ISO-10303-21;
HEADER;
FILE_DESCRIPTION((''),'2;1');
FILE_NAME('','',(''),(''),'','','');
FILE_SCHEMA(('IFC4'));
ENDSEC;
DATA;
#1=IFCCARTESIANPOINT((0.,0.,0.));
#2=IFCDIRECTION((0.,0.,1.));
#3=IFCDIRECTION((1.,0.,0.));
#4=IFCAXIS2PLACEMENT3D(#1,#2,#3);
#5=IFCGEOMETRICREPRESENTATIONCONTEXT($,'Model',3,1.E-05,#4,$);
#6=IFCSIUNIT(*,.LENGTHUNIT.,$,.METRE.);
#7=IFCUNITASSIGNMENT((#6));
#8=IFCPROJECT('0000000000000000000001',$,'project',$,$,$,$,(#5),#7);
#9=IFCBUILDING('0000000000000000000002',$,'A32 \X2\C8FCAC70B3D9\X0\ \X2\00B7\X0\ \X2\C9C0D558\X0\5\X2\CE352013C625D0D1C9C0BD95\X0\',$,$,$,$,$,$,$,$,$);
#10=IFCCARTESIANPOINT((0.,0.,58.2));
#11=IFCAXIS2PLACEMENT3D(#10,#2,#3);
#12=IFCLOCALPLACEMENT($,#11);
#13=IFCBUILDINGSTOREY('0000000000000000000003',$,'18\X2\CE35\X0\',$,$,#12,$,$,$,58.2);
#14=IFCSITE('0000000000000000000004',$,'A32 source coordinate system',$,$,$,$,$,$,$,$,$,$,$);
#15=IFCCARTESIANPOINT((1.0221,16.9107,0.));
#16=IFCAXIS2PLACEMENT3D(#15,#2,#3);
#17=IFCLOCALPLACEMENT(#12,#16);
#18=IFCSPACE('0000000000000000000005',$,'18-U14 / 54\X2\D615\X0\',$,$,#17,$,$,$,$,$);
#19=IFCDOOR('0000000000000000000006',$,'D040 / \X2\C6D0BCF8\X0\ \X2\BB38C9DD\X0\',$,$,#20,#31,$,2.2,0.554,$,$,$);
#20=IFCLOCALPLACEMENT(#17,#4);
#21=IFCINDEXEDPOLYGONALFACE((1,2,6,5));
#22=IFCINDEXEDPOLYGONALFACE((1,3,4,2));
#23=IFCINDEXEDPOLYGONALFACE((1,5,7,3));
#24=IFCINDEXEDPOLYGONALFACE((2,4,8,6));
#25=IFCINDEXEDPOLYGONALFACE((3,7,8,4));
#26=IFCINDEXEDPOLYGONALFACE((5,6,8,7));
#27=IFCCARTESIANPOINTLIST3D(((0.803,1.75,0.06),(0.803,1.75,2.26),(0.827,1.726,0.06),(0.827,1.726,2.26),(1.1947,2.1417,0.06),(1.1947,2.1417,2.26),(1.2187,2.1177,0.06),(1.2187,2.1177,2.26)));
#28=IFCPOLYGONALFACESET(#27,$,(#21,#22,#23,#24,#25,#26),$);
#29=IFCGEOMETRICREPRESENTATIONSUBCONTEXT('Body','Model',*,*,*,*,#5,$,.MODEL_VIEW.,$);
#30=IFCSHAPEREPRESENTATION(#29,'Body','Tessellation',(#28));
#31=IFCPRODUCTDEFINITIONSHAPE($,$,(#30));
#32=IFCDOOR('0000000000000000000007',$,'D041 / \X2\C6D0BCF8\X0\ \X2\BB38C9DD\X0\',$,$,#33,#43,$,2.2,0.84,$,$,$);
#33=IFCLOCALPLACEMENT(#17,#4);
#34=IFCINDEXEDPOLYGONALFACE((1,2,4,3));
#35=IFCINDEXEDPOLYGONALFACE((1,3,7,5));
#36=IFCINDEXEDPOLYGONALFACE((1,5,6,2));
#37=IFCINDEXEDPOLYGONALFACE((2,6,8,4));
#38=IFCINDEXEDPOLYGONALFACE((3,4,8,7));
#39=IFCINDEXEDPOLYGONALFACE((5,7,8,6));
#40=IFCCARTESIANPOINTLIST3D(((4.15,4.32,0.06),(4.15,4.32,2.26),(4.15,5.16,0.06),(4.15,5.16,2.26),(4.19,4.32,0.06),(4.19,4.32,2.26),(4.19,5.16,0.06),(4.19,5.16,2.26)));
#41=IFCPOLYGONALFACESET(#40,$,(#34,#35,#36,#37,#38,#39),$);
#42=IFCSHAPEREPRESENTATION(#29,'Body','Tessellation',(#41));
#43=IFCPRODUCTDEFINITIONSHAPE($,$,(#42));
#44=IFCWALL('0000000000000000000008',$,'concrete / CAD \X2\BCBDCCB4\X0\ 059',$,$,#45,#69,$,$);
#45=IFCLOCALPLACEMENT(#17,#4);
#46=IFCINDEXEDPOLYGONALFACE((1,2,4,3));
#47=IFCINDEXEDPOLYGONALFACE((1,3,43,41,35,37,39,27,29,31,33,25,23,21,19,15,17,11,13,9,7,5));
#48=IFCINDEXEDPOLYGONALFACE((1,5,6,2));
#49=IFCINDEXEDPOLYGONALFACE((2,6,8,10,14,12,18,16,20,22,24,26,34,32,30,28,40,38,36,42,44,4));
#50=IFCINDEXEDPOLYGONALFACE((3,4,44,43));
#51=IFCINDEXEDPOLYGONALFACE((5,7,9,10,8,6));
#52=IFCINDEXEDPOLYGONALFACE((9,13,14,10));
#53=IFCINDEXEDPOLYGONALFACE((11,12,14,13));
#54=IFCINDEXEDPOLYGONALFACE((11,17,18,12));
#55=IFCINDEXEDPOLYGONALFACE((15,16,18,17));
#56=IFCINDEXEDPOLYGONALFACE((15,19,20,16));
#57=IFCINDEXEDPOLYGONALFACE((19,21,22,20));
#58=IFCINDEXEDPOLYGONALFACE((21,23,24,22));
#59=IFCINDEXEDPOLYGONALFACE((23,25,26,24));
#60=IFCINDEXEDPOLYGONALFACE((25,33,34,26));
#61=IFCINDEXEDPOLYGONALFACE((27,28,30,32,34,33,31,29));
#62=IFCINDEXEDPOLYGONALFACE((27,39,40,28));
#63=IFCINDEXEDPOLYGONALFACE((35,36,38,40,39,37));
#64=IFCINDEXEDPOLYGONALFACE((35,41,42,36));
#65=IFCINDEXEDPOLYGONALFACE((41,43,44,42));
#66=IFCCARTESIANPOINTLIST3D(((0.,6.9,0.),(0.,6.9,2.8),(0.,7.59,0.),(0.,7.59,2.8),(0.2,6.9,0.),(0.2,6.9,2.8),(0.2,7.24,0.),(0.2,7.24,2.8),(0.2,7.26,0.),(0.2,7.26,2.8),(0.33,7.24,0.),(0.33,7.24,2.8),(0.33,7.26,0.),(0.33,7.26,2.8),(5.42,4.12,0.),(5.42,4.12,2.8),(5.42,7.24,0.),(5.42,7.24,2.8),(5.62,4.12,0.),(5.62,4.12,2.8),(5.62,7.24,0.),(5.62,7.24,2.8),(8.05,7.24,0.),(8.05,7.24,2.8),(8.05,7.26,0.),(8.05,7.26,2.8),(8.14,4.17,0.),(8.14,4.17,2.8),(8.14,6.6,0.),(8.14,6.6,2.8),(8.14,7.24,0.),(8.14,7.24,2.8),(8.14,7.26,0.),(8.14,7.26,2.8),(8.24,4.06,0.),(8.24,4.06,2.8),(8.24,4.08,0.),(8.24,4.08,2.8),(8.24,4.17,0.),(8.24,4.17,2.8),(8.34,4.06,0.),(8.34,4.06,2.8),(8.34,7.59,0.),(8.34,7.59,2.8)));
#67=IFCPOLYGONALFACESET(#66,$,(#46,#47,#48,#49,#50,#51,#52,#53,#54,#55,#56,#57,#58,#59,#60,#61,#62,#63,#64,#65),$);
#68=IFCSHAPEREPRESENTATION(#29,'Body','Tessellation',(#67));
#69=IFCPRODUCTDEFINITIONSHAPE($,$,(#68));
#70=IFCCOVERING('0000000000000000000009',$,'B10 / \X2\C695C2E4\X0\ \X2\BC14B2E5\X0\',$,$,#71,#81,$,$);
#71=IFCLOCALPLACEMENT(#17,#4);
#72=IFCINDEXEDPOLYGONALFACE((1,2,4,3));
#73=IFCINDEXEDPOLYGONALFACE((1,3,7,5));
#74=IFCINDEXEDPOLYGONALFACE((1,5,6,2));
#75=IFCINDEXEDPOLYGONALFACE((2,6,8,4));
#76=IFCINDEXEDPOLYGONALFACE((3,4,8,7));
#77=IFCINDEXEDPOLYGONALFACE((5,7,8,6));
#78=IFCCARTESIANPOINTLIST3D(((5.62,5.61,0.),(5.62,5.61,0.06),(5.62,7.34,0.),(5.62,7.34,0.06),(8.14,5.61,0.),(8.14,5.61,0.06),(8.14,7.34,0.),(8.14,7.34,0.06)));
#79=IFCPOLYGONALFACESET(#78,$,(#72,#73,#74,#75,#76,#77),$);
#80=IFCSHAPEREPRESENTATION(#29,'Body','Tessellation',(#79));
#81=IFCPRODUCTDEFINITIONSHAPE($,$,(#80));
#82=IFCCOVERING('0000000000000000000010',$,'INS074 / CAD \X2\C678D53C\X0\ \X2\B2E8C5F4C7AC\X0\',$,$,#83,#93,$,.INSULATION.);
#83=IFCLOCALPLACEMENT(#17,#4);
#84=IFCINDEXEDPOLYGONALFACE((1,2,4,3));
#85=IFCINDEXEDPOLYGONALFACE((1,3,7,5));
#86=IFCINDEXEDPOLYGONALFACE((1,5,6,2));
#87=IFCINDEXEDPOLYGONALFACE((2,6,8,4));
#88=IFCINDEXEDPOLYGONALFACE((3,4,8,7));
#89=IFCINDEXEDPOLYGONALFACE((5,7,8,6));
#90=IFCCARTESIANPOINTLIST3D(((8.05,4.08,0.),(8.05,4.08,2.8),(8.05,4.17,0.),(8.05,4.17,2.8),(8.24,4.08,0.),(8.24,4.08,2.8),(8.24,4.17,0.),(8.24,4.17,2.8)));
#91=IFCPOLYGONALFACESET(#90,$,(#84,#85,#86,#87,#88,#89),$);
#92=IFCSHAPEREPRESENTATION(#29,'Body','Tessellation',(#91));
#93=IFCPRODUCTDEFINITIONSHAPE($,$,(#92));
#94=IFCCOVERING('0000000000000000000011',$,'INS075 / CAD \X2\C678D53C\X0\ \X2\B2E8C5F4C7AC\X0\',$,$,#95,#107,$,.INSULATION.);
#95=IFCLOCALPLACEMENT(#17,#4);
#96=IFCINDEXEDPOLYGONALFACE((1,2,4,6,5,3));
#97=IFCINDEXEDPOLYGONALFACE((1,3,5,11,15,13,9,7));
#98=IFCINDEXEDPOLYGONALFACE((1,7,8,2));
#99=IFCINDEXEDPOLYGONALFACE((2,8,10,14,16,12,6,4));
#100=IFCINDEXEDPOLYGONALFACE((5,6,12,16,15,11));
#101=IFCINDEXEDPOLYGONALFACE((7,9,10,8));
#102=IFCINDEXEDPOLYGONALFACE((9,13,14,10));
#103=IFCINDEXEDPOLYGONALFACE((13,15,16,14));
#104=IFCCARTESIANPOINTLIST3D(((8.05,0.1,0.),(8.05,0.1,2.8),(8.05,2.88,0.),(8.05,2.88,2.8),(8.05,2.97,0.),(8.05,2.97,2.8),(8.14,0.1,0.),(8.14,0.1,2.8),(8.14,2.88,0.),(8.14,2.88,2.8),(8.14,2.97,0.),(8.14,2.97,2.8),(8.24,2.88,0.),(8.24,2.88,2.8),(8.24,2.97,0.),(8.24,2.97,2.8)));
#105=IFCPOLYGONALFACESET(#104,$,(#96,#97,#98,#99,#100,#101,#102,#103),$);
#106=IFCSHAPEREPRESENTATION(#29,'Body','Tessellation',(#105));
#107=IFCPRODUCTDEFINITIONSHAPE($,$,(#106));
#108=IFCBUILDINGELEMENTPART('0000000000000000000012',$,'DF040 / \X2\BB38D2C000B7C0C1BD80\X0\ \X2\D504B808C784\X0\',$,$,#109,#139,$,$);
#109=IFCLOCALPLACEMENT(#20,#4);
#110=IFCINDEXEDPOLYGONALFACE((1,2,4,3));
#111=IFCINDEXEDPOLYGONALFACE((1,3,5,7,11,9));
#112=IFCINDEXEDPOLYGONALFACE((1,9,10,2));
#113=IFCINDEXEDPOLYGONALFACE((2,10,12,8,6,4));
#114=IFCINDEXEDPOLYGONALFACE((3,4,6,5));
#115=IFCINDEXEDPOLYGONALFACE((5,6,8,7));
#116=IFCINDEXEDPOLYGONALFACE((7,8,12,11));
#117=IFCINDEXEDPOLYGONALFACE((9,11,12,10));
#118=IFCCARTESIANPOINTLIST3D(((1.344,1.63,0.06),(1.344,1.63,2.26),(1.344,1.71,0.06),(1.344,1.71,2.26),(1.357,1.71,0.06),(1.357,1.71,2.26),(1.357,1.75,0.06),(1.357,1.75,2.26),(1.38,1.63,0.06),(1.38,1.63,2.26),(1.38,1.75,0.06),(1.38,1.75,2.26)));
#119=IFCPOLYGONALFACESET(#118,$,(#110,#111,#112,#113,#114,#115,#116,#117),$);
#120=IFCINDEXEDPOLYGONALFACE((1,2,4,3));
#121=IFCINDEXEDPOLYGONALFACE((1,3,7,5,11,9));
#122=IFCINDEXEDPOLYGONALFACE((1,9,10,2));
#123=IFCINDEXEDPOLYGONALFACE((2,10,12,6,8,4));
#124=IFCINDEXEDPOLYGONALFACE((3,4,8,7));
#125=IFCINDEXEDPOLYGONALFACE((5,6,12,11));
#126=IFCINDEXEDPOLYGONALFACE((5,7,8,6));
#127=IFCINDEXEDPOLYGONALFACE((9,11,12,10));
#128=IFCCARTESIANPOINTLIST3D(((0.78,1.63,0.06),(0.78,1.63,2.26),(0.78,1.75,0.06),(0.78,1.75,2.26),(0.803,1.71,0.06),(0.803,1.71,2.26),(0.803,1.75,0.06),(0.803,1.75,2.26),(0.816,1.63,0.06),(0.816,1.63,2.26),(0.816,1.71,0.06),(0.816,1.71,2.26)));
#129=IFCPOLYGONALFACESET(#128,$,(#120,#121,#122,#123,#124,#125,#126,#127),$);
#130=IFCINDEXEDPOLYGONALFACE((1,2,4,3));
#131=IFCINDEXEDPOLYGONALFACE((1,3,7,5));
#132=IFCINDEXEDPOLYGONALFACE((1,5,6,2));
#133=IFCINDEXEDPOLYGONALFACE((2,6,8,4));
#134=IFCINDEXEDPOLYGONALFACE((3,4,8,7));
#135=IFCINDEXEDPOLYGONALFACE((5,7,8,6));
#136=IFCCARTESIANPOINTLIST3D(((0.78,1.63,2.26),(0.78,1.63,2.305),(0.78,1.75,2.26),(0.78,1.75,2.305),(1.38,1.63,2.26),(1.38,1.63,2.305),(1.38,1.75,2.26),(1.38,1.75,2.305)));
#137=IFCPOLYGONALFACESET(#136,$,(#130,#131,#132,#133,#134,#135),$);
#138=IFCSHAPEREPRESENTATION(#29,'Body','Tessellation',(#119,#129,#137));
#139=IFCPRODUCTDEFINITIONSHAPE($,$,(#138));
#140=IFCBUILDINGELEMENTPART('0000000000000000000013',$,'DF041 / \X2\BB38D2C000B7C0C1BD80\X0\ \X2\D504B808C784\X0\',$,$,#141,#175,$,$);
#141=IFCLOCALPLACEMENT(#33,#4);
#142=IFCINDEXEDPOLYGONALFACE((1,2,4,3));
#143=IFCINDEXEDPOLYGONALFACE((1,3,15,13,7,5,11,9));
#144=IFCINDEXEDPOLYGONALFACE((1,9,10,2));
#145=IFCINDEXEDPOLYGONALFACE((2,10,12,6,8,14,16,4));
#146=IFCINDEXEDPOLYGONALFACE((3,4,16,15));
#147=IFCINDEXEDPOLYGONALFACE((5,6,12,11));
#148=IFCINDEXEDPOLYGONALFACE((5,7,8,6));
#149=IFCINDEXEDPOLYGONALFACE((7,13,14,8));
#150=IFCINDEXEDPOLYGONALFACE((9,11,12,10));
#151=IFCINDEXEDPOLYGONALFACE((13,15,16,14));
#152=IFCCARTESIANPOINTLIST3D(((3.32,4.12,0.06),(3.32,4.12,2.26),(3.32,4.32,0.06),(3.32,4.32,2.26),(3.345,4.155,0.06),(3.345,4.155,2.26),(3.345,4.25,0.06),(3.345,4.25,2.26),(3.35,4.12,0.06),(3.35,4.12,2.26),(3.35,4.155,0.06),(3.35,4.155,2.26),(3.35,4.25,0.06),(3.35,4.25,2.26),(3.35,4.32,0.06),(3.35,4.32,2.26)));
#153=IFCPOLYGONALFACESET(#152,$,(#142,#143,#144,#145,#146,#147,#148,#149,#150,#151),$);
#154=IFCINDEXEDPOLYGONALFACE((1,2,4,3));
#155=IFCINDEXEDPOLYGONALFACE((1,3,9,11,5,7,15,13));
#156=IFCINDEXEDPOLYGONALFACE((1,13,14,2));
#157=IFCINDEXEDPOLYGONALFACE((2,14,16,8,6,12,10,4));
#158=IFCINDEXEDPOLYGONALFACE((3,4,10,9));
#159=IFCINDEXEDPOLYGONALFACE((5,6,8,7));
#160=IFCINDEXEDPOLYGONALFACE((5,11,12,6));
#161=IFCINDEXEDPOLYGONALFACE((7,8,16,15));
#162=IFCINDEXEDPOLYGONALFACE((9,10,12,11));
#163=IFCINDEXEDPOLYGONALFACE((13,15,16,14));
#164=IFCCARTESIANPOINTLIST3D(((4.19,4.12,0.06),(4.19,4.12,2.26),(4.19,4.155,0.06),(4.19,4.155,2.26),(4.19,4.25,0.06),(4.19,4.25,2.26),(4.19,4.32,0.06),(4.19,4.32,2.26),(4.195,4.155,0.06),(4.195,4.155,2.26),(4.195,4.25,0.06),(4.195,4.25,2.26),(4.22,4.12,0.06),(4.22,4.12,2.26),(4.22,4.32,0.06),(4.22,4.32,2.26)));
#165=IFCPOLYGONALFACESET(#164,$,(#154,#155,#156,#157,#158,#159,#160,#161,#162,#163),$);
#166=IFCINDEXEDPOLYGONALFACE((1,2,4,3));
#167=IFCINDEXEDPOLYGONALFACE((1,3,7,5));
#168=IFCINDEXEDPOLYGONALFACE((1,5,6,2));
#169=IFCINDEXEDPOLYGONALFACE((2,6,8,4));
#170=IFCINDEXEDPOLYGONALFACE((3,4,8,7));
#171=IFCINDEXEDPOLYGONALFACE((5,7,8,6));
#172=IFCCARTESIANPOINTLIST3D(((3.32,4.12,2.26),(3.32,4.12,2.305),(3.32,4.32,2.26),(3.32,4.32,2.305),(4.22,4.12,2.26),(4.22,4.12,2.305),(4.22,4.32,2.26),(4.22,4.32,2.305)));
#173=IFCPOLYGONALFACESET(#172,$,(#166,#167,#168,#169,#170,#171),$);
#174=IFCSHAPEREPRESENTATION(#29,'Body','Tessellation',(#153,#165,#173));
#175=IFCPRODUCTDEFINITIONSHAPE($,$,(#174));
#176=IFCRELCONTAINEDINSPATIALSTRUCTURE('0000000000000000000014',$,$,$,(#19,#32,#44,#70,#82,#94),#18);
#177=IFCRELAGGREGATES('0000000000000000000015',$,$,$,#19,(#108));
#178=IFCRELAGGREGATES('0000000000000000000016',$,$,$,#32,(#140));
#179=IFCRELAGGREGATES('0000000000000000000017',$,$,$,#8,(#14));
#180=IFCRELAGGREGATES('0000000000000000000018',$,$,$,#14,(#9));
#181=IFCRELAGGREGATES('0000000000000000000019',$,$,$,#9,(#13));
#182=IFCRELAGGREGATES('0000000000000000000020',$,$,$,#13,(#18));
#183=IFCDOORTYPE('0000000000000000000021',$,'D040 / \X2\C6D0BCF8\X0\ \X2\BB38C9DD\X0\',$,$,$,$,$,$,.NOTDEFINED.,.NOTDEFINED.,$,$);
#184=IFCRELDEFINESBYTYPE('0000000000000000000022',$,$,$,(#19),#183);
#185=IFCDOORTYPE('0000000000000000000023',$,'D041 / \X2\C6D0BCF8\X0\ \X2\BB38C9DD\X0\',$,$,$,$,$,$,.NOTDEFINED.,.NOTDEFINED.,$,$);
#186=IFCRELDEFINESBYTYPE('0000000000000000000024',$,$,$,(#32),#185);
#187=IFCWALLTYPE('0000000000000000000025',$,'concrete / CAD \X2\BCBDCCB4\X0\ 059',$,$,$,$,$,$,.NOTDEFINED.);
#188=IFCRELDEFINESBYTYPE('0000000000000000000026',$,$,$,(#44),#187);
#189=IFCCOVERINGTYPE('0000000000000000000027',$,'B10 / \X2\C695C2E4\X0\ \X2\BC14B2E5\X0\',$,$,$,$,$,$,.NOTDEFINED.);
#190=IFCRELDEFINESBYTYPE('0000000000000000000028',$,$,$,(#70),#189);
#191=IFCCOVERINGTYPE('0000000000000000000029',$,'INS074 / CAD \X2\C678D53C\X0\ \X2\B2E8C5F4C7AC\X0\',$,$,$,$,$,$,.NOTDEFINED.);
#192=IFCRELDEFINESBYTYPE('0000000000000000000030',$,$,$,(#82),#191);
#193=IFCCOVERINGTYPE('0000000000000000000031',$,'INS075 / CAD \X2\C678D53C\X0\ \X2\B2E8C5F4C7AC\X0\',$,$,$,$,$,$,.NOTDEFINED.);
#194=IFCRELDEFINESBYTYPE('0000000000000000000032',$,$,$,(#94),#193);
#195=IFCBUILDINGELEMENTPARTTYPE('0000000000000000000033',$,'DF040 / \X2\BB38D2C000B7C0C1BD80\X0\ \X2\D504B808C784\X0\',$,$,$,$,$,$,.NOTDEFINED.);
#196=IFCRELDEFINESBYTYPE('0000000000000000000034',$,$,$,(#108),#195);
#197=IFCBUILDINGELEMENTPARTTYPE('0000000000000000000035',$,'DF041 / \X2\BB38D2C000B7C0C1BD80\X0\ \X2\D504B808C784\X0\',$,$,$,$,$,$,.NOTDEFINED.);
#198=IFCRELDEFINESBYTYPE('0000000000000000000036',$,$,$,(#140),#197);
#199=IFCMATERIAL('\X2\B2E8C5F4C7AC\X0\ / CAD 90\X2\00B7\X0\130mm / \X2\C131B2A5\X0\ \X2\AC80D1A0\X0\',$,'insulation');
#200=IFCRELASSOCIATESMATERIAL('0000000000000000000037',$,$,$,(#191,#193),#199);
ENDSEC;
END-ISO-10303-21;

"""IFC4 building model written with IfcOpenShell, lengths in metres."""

from ifc_helpers import new_model, si_unit, frame, origin, origin_with_axes, place, context, subcontext, project, spatial, polyline, outline, extrude, source, transform, mapped, material, type_object, type_shapes, element, aggregate, save


model = new_model("IFC4")

# Units and contexts
model_context = context("Model", 3, precision=1e-05, world=origin_with_axes())
body_context = subcontext(model_context, "Body", "Model", "MODEL_VIEW")
ifc_project = project(units=[si_unit("LENGTHUNIT", "METRE")], contexts=[model_context])

# Site, building, storey, space
storey_placement = place(None, frame((0.0, 0.0, 58.2), z_axis=(0.0, 0.0, 1.0), x_axis=(1.0, 0.0, 0.0)))
space_1_placement = place(storey_placement, frame((1.0221, 16.9107, 0.0), z_axis=(0.0, 0.0, 1.0), x_axis=(1.0, 0.0, 0.0)))
site = spatial("IfcSite", under=ifc_project, Name="A32 source coordinate system")
building = spatial("IfcBuilding", under=site, Name="A32 주거동 · 지하5층–옥탑지붕")
storey = spatial("IfcBuildingStorey", under=building, at=storey_placement, Name="18층", Elevation=58.2)
space_1 = spatial("IfcSpace", under=storey, at=space_1_placement, Name="18-U14 / 54형")

# Doors
door_type_1 = type_object("IfcDoorType", Name="D040 / 원본 문짝", OperationType="NOTDEFINED", PredefinedType="NOTDEFINED")
shared_shape_1 = source(origin(), body_context, "Body", "SweptSolid", [
    extrude(outline(polyline([(0.803, 1.75), (1.1947, 2.1417), (1.2187, 2.1177), (0.827, 1.726), (0.803, 1.75)])), frame((0.0, 0.0, 0.06)), (0.0, 0.0, 1.0), 2.2),
])
type_shapes(door_type_1, [shared_shape_1])
door_1_placement = place(space_1_placement, origin_with_axes())
door_1 = element("IfcDoor", 1, at=door_1_placement, inside=space_1, type_object=door_type_1, Name="D040 / 원본 문짝", OverallHeight=2.2, OverallWidth=0.554, context=body_context, shape_type="MappedRepresentation", body=[
    mapped(shared_shape_1, transform((0.0, 0.0, 0.0), scale=1.0)),
])
door_type_2 = type_object("IfcDoorType", Name="D041 / 원본 문짝", OperationType="NOTDEFINED", PredefinedType="NOTDEFINED")
shared_shape_2 = source(origin(), body_context, "Body", "SweptSolid", [
    extrude(outline(polyline([(4.15, 5.16), (4.19, 5.16), (4.19, 4.32), (4.15, 4.32), (4.15, 5.16)])), frame((0.0, 0.0, 0.06)), (0.0, 0.0, 1.0), 2.2),
])
type_shapes(door_type_2, [shared_shape_2])
door_2_placement = place(space_1_placement, origin_with_axes())
door_2 = element("IfcDoor", 2, at=door_2_placement, inside=space_1, type_object=door_type_2, Name="D041 / 원본 문짝", OverallHeight=2.2, OverallWidth=0.84, context=body_context, shape_type="MappedRepresentation", body=[
    mapped(shared_shape_2, transform((0.0, 0.0, 0.0), scale=1.0)),
])

# Wall
wall_type_1 = type_object("IfcWallType", Name="concrete / CAD 벽체 059", PredefinedType="NOTDEFINED")
shared_shape_3 = source(origin(), body_context, "Body", "SweptSolid", [
    extrude(outline(polyline([(8.05, 7.26), (8.05, 7.24), (5.62, 7.24), (5.62, 4.12), (5.42, 4.12), (5.42, 7.24), (0.33, 7.24), (0.33, 7.26), (0.2, 7.26), (0.2, 7.24), (0.2, 6.9), (0.0, 6.9), (0.0, 7.59), (8.34, 7.59), (8.34, 4.06), (8.24, 4.06), (8.24, 4.08), (8.24, 4.17), (8.14, 4.17), (8.14, 6.6), (8.14, 7.24), (8.14, 7.26), (8.05, 7.26)])), origin(), (0.0, 0.0, 1.0), 2.8),
])
type_shapes(wall_type_1, [shared_shape_3])
wall_1_placement = place(space_1_placement, origin_with_axes())
element("IfcWall", 3, at=wall_1_placement, inside=space_1, type_object=wall_type_1, Name="concrete / CAD 벽체 059", context=body_context, shape_type="MappedRepresentation", body=[
    mapped(shared_shape_3, transform((0.0, 0.0, 0.0), scale=1.0)),
])

# Coverings
covering_type_1 = type_object("IfcCoveringType", Name="B10 / 욕실 바닥", PredefinedType="NOTDEFINED")
shared_shape_4 = source(origin(), body_context, "Body", "SweptSolid", [
    extrude(outline(polyline([(8.14, 5.61), (5.62, 5.61), (5.62, 7.34), (8.14, 7.34), (8.14, 5.61)])), origin(), (0.0, 0.0, 1.0), 0.06),
])
type_shapes(covering_type_1, [shared_shape_4])
covering_1_placement = place(space_1_placement, origin_with_axes())
element("IfcCovering", 4, at=covering_1_placement, inside=space_1, type_object=covering_type_1, Name="B10 / 욕실 바닥", context=body_context, shape_type="MappedRepresentation", body=[
    mapped(shared_shape_4, transform((0.0, 0.0, 0.0), scale=1.0)),
])
ifc_material = material(Name="단열재 / CAD 90·130mm / 성능 검토", Category="insulation")
covering_type_2 = type_object("IfcCoveringType", Name="INS074 / CAD 외피 단열재", PredefinedType="NOTDEFINED", material=ifc_material)
shared_shape_5 = source(origin(), body_context, "Body", "SweptSolid", [
    extrude(outline(polyline([(8.05, 4.08), (8.05, 4.17), (8.24, 4.17), (8.24, 4.08), (8.05, 4.08)])), origin(), (0.0, 0.0, 1.0), 2.8),
])
type_shapes(covering_type_2, [shared_shape_5])
covering_2_placement = place(space_1_placement, origin_with_axes())
element("IfcCovering", 5, at=covering_2_placement, inside=space_1, type_object=covering_type_2, Name="INS074 / CAD 외피 단열재", PredefinedType="INSULATION", context=body_context, shape_type="MappedRepresentation", body=[
    mapped(shared_shape_5, transform((0.0, 0.0, 0.0), scale=1.0)),
])
covering_type_3 = type_object("IfcCoveringType", Name="INS075 / CAD 외피 단열재", PredefinedType="NOTDEFINED", material=ifc_material)
shared_shape_6 = source(origin(), body_context, "Body", "SweptSolid", [
    extrude(outline(polyline([(8.24, 2.88), (8.14, 2.88), (8.14, 0.1), (8.05, 0.1), (8.05, 2.88), (8.05, 2.97), (8.14, 2.97), (8.24, 2.97), (8.24, 2.88)])), origin(), (0.0, 0.0, 1.0), 2.8),
])
type_shapes(covering_type_3, [shared_shape_6])
covering_3_placement = place(space_1_placement, origin_with_axes())
element("IfcCovering", 6, at=covering_3_placement, inside=space_1, type_object=covering_type_3, Name="INS075 / CAD 외피 단열재", PredefinedType="INSULATION", context=body_context, shape_type="MappedRepresentation", body=[
    mapped(shared_shape_6, transform((0.0, 0.0, 0.0), scale=1.0)),
])

# Building element parts
building_element_part_type_1 = type_object("IfcBuildingElementPartType", Name="DF040 / 문틀·상부 프레임", PredefinedType="NOTDEFINED")
shared_shape_7 = source(origin(), body_context, "Body", "SweptSolid", [
    extrude(outline(polyline([(1.344, 1.63), (1.344, 1.71), (1.357, 1.71), (1.357, 1.75), (1.38, 1.75), (1.38, 1.63), (1.344, 1.63)])), frame((0.0, 0.0, 0.06)), (0.0, 0.0, 1.0), 2.2),
    extrude(outline(polyline([(0.78, 1.75), (0.803, 1.75), (0.803, 1.71), (0.816, 1.71), (0.816, 1.63), (0.78, 1.63), (0.78, 1.75)])), frame((0.0, 0.0, 0.06)), (0.0, 0.0, 1.0), 2.2),
    extrude(outline(polyline([(0.78, 1.63), (0.78, 1.75), (1.38, 1.75), (1.38, 1.63), (0.78, 1.63)])), frame((0.0, 0.0, 2.26)), (0.0, 0.0, 1.0), 0.045),
])
type_shapes(building_element_part_type_1, [shared_shape_7])
building_element_part_1_placement = place(door_1_placement, origin_with_axes())
building_element_part_1 = element("IfcBuildingElementPart", 7, at=building_element_part_1_placement, type_object=building_element_part_type_1, Name="DF040 / 문틀·상부 프레임", context=body_context, shape_type="MappedRepresentation", body=[
    mapped(shared_shape_7, transform((0.0, 0.0, 0.0), scale=1.0)),
])
aggregate(door_1, [building_element_part_1])
building_element_part_type_2 = type_object("IfcBuildingElementPartType", Name="DF041 / 문틀·상부 프레임", PredefinedType="NOTDEFINED")
shared_shape_8 = source(origin(), body_context, "Body", "SweptSolid", [
    extrude(outline(polyline([(3.35, 4.32), (3.35, 4.25), (3.345, 4.25), (3.345, 4.155), (3.35, 4.155), (3.35, 4.12), (3.32, 4.12), (3.32, 4.32), (3.35, 4.32)])), frame((0.0, 0.0, 0.06)), (0.0, 0.0, 1.0), 2.2),
    extrude(outline(polyline([(4.22, 4.12), (4.19, 4.12), (4.19, 4.155), (4.195, 4.155), (4.195, 4.25), (4.19, 4.25), (4.19, 4.32), (4.22, 4.32), (4.22, 4.12)])), frame((0.0, 0.0, 0.06)), (0.0, 0.0, 1.0), 2.2),
    extrude(outline(polyline([(3.32, 4.12), (3.32, 4.32), (4.22, 4.32), (4.22, 4.12), (3.32, 4.12)])), frame((0.0, 0.0, 2.26)), (0.0, 0.0, 1.0), 0.045),
])
type_shapes(building_element_part_type_2, [shared_shape_8])
building_element_part_2_placement = place(door_2_placement, origin_with_axes())
building_element_part_2 = element("IfcBuildingElementPart", 8, at=building_element_part_2_placement, type_object=building_element_part_type_2, Name="DF041 / 문틀·상부 프레임", context=body_context, shape_type="MappedRepresentation", body=[
    mapped(shared_shape_8, transform((0.0, 0.0, 0.0), scale=1.0)),
])
aggregate(door_2, [building_element_part_2])

save(model, "model.ifc")
